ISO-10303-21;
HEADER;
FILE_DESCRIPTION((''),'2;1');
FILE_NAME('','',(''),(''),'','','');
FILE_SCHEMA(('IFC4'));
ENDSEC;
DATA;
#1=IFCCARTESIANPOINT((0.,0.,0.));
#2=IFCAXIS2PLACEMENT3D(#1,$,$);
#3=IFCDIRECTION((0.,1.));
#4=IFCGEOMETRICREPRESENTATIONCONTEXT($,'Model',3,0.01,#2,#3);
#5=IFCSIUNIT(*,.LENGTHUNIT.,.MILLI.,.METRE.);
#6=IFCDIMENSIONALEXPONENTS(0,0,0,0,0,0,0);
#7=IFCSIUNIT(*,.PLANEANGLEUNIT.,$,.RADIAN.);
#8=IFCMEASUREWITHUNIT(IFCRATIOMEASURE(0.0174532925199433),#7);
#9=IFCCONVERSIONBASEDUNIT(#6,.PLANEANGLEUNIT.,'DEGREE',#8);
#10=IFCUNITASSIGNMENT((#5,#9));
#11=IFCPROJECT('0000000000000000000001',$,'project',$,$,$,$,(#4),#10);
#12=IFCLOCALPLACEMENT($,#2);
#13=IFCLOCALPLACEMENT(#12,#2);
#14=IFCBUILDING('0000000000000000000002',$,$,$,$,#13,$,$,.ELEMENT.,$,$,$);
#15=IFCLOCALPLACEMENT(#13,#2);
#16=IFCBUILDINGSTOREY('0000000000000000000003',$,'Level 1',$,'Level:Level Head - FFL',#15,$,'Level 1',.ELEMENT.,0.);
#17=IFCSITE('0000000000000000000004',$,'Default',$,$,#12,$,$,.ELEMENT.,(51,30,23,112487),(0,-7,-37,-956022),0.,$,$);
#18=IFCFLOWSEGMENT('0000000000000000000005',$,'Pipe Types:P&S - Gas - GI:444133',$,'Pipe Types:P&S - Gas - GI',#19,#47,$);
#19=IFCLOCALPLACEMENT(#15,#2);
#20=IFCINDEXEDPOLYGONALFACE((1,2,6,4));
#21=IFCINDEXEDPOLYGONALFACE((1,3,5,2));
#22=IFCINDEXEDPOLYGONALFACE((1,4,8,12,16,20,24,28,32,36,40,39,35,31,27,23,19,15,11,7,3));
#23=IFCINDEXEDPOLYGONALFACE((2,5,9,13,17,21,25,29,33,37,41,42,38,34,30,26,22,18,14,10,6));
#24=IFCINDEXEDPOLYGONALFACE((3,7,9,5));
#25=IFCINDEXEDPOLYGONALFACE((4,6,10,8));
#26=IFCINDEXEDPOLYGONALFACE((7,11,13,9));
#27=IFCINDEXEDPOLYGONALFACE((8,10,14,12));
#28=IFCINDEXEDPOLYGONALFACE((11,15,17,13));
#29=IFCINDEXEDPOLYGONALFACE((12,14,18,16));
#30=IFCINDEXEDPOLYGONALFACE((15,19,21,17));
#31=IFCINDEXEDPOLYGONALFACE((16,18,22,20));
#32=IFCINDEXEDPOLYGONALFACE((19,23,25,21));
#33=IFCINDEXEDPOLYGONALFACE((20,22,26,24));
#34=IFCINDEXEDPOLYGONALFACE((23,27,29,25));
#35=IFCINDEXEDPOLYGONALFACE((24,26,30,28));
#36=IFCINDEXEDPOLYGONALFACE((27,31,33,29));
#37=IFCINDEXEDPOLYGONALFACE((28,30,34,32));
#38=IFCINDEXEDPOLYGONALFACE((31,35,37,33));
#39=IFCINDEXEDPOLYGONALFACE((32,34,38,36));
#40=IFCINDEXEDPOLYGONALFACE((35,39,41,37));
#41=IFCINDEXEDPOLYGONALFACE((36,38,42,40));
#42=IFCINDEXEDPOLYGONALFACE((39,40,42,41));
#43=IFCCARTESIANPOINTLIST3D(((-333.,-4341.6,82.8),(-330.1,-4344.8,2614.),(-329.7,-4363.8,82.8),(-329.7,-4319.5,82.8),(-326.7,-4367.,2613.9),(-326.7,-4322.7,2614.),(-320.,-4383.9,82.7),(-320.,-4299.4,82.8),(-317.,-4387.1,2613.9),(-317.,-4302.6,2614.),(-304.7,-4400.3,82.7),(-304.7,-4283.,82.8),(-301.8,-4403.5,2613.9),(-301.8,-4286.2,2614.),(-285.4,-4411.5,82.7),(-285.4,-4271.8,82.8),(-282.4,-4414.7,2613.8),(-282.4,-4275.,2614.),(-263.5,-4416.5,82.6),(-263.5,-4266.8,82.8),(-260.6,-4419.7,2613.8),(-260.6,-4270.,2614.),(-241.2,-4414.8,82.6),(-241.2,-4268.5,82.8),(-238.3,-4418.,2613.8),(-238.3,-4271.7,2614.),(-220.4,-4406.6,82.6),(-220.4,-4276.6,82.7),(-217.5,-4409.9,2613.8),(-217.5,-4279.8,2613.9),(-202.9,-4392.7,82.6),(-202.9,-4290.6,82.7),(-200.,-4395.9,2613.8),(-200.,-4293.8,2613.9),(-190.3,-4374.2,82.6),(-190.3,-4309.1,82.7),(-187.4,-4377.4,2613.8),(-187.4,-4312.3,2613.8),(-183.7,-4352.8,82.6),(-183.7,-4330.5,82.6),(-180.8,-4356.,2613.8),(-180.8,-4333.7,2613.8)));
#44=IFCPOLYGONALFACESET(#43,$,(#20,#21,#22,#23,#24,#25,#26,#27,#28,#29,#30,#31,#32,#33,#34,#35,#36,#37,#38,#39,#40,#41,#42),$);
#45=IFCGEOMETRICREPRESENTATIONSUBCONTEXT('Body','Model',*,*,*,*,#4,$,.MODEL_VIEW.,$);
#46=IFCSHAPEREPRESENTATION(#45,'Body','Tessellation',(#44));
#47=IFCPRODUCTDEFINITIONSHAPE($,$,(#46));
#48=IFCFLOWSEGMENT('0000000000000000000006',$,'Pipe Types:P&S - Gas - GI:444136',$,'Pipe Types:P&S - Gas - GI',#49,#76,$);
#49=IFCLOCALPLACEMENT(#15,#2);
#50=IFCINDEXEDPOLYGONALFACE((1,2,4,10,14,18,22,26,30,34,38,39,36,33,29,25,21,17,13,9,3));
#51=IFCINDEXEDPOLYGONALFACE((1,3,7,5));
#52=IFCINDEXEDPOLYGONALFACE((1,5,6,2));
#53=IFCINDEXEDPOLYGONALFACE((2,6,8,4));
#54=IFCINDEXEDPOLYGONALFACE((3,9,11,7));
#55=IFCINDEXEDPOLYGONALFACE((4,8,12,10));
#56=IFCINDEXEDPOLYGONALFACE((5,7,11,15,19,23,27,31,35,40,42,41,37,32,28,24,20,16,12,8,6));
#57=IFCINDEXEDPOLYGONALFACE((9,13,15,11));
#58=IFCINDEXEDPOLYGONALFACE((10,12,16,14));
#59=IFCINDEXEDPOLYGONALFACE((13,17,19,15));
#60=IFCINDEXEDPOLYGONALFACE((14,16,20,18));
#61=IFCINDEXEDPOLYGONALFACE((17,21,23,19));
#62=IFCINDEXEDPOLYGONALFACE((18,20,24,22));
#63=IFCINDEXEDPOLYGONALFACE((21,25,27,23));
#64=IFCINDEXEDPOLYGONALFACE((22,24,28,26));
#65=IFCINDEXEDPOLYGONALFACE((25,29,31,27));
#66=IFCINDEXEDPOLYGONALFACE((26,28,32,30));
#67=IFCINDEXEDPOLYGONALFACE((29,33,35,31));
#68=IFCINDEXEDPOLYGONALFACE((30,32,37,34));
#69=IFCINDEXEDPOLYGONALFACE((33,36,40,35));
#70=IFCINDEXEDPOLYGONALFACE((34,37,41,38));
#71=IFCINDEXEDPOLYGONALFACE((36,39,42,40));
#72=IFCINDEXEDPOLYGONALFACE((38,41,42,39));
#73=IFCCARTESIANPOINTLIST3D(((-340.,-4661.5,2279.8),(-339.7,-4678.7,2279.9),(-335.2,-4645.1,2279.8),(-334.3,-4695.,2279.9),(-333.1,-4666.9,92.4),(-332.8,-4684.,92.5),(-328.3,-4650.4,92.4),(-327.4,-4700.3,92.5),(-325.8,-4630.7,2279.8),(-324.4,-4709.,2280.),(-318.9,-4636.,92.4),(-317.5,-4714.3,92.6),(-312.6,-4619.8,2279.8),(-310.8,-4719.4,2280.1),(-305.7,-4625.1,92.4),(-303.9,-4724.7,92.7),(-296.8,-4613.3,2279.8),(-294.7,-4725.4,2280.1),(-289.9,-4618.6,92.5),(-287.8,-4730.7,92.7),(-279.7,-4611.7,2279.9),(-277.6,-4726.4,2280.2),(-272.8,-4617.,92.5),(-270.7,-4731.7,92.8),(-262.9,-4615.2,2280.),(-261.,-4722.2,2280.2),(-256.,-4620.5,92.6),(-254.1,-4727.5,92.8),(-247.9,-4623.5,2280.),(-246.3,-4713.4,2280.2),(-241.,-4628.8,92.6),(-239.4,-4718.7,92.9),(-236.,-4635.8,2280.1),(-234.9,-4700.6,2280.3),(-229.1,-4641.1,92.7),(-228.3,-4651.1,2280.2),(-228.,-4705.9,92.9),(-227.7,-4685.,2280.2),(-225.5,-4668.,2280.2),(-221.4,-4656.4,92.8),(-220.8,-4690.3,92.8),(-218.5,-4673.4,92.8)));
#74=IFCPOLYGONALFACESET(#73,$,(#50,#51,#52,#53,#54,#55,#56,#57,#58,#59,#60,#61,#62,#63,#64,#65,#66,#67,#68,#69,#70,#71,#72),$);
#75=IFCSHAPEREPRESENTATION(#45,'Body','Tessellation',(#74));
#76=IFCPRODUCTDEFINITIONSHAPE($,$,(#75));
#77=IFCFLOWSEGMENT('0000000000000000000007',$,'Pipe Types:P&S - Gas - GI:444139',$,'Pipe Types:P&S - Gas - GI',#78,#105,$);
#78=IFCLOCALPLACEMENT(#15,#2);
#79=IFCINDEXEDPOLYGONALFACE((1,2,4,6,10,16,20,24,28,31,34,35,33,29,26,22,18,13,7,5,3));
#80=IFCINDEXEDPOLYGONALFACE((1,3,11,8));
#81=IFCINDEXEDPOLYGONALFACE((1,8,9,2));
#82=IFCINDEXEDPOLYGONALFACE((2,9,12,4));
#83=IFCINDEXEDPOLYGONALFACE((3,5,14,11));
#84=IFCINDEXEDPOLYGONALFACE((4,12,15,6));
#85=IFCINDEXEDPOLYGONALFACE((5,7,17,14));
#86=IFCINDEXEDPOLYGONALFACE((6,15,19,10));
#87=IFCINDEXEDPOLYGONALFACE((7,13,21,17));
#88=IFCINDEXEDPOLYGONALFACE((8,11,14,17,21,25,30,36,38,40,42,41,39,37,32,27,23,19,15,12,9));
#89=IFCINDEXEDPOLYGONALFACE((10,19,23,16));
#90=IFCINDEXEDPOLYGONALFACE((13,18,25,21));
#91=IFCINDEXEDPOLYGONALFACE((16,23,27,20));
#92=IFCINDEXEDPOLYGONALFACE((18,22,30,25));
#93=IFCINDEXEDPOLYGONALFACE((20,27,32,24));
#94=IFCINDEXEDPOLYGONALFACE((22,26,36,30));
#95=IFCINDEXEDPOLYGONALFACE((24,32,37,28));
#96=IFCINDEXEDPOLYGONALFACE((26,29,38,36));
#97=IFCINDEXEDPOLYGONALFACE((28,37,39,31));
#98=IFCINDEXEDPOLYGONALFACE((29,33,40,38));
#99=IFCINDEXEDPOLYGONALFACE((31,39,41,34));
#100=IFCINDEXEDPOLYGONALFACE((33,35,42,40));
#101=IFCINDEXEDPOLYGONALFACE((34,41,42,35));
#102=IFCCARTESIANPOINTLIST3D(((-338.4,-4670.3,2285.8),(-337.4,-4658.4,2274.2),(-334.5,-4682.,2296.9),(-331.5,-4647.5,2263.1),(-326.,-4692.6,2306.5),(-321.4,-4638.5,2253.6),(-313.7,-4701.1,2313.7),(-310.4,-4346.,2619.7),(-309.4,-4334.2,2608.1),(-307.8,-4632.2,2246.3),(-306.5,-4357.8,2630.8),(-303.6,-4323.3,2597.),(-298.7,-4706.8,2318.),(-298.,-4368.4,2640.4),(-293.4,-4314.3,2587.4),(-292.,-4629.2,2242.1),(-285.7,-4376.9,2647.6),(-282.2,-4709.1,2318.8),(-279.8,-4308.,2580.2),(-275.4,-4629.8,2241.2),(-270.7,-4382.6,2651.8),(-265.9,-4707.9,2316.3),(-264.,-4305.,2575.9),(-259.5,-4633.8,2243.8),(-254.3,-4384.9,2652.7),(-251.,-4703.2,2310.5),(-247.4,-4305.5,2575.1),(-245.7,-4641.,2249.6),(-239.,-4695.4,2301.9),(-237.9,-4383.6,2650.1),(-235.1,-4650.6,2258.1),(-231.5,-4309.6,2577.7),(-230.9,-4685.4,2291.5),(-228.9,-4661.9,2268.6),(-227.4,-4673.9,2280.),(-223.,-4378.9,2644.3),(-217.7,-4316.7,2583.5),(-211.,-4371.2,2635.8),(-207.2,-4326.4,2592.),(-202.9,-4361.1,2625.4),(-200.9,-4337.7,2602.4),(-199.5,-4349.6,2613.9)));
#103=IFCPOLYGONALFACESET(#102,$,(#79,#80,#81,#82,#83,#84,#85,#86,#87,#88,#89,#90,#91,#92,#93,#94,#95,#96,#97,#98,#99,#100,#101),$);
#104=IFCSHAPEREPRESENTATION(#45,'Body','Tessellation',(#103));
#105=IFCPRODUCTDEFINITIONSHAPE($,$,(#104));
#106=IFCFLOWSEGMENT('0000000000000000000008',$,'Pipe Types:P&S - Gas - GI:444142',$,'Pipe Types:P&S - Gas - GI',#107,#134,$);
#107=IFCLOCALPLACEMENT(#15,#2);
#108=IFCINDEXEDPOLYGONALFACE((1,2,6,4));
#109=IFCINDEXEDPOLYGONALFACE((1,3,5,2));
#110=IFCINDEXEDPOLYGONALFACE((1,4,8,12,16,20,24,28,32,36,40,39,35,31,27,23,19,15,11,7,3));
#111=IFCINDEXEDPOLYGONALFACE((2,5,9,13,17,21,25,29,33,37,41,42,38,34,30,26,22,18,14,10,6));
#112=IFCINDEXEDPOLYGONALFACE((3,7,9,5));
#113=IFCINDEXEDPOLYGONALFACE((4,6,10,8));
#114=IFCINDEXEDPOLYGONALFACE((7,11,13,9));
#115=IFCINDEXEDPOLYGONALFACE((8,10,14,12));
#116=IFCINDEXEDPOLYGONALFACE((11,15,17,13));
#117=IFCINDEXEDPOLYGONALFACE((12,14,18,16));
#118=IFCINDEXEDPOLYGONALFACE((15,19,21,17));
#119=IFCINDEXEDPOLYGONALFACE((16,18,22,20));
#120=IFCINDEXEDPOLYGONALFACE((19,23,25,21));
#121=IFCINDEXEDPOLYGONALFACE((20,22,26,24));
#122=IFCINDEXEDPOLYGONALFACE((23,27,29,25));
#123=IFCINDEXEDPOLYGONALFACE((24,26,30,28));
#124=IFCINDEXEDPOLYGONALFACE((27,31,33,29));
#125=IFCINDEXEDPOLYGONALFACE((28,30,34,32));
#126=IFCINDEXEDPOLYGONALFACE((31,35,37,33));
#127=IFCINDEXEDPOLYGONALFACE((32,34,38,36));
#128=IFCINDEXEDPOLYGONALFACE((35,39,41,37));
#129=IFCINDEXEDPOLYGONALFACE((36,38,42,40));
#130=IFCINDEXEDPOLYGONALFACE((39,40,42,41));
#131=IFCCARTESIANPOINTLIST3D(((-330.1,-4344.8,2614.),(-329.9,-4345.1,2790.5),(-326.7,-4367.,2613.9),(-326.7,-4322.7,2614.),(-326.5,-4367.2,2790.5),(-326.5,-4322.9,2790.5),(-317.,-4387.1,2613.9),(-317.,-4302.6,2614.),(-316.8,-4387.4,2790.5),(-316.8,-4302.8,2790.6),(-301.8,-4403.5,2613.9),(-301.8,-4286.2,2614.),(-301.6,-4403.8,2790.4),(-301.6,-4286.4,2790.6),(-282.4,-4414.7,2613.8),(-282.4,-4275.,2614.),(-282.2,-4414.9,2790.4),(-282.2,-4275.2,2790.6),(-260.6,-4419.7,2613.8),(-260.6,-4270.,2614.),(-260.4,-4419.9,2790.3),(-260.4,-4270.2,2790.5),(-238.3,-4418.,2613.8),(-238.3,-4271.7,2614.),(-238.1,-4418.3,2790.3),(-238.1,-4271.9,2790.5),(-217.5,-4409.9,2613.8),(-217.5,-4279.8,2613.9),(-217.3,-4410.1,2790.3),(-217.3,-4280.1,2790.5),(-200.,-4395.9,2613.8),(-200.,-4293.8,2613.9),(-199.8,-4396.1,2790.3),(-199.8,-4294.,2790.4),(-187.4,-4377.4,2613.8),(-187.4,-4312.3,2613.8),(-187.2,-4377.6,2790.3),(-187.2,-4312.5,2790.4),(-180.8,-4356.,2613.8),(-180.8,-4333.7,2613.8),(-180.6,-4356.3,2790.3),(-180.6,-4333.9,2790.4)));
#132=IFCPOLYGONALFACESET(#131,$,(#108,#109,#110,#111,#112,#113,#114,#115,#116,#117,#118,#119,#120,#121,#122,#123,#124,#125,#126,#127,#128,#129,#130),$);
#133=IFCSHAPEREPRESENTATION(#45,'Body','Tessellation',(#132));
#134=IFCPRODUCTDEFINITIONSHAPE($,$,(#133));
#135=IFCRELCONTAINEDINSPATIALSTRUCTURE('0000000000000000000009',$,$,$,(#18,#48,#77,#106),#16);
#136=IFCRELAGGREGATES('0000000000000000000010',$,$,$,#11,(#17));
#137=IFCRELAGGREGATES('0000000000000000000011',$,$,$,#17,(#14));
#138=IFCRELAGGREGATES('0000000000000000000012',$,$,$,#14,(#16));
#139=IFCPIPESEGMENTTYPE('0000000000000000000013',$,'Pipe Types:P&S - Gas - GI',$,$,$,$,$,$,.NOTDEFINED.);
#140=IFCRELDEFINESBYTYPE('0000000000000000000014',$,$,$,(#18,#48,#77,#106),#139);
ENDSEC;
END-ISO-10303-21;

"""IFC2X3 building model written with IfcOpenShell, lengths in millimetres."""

from ifc_helpers import new_model, entity, si_unit, converted_unit, direction, frame, frame_2d, origin, origin_2d_with_axis, place, context, subcontext, project, spatial, circle, extrude, type_object, element, save


model = new_model("IFC2X3")

# Units and contexts
model_context = context("Model", 3, precision=0.01, world=origin(), true_north=direction((0.0, 1.0)))
body_context = subcontext(model_context, "Body", "Model", "MODEL_VIEW")
ifc_project = project(units=[si_unit("LENGTHUNIT", "METRE", prefix="MILLI"), converted_unit("PLANEANGLEUNIT", "DEGREE", entity("IfcRatioMeasure", 0.0174532925199433), si_unit("PLANEANGLEUNIT", "RADIAN"), dimensions=[0, 0, 0, 0, 0, 0, 0])], contexts=[model_context])

# Site, building, storey
site_placement = place(None, origin())
site = spatial("IfcSite", under=ifc_project, at=site_placement, Name="Default", CompositionType="ELEMENT", RefLatitude=(51, 30, 23, 112487), RefLongitude=(0, -7, -37, -956022), RefElevation=0.0)
building_placement = place(site_placement, origin())
building = spatial("IfcBuilding", under=site, at=building_placement, CompositionType="ELEMENT")
storey_placement = place(building_placement, origin())
storey = spatial("IfcBuildingStorey", under=building, at=storey_placement, Name="Level 1", ObjectType="Level:Level Head - FFL", LongName="Level 1", CompositionType="ELEMENT", Elevation=0.0)

# Flow segments
pipe_segment_type = type_object("IfcPipeSegmentType", Name="Pipe Types:P&S - Gas - GI", PredefinedType="NOTDEFINED")
flow_segment_1_placement = place(storey_placement, origin())
element("IfcFlowSegment", 1, at=flow_segment_1_placement, inside=storey, type_object=pipe_segment_type, Name="Pipe Types:P&S - Gas - GI:444133", ObjectType="Pipe Types:P&S - Gas - GI", context=body_context, shape_type="SweptSolid", body=[
    extrude(circle(Radius=75.1, at=frame_2d((0.0, 0.0), x_axis=(1.0, 0.0))), frame((-257.9, -4341.6, 82.7), z_axis=(0.00116, -0.001268, 0.999999), x_axis=(-0.999999, 0.0, 0.00116)), (0.0, 0.0, 1.0), 2531.2),
])
flow_segment_2_placement = place(storey_placement, origin())
element("IfcFlowSegment", 2, at=flow_segment_2_placement, inside=storey, type_object=pipe_segment_type, Name="Pipe Types:P&S - Gas - GI:444136", ObjectType="Pipe Types:P&S - Gas - GI", context=body_context, shape_type="SweptSolid", body=[
    extrude(circle(Radius=57.5, at=frame_2d((0.0, 0.0), x_axis=(1.0, 0.0))), frame((-276.1, -4674.4, 92.6), z_axis=(-0.00316, 0.002428, 0.999992), x_axis=(0.609187, 0.793026, 0.0)), (0.0, 0.0, 1.0), 2187.4),
])
flow_segment_3_placement = place(storey_placement, origin())
element("IfcFlowSegment", 3, at=flow_segment_3_placement, inside=storey, type_object=pipe_segment_type, Name="Pipe Types:P&S - Gas - GI:444139", ObjectType="Pipe Types:P&S - Gas - GI", context=body_context, shape_type="SweptSolid", body=[
    extrude(circle(Radius=55.8, at=origin_2d_with_axis()), frame((-283.0, -4669.1, 2280.0), z_axis=(0.059995, 0.695438, 0.716078), x_axis=(0.996299, -0.085951, 0.0)), (0.0, 0.0, 1.0), 466.2),
])
flow_segment_4_placement = place(storey_placement, origin())
element("IfcFlowSegment", 4, at=flow_segment_4_placement, inside=storey, type_object=pipe_segment_type, Name="Pipe Types:P&S - Gas - GI:444142", ObjectType="Pipe Types:P&S - Gas - GI", context=body_context, shape_type="SweptSolid", body=[
    extrude(circle(Radius=75.1, at=frame_2d((0.0, 0.0), x_axis=(1.0, 0.0))), frame((-255.0, -4344.8, 2613.9), z_axis=(0.00116, -0.001268, 0.999999), x_axis=(-0.999999, 0.0, 0.00116)), (0.0, 0.0, 1.0), 176.6),
])

save(model, "model.ifc")
